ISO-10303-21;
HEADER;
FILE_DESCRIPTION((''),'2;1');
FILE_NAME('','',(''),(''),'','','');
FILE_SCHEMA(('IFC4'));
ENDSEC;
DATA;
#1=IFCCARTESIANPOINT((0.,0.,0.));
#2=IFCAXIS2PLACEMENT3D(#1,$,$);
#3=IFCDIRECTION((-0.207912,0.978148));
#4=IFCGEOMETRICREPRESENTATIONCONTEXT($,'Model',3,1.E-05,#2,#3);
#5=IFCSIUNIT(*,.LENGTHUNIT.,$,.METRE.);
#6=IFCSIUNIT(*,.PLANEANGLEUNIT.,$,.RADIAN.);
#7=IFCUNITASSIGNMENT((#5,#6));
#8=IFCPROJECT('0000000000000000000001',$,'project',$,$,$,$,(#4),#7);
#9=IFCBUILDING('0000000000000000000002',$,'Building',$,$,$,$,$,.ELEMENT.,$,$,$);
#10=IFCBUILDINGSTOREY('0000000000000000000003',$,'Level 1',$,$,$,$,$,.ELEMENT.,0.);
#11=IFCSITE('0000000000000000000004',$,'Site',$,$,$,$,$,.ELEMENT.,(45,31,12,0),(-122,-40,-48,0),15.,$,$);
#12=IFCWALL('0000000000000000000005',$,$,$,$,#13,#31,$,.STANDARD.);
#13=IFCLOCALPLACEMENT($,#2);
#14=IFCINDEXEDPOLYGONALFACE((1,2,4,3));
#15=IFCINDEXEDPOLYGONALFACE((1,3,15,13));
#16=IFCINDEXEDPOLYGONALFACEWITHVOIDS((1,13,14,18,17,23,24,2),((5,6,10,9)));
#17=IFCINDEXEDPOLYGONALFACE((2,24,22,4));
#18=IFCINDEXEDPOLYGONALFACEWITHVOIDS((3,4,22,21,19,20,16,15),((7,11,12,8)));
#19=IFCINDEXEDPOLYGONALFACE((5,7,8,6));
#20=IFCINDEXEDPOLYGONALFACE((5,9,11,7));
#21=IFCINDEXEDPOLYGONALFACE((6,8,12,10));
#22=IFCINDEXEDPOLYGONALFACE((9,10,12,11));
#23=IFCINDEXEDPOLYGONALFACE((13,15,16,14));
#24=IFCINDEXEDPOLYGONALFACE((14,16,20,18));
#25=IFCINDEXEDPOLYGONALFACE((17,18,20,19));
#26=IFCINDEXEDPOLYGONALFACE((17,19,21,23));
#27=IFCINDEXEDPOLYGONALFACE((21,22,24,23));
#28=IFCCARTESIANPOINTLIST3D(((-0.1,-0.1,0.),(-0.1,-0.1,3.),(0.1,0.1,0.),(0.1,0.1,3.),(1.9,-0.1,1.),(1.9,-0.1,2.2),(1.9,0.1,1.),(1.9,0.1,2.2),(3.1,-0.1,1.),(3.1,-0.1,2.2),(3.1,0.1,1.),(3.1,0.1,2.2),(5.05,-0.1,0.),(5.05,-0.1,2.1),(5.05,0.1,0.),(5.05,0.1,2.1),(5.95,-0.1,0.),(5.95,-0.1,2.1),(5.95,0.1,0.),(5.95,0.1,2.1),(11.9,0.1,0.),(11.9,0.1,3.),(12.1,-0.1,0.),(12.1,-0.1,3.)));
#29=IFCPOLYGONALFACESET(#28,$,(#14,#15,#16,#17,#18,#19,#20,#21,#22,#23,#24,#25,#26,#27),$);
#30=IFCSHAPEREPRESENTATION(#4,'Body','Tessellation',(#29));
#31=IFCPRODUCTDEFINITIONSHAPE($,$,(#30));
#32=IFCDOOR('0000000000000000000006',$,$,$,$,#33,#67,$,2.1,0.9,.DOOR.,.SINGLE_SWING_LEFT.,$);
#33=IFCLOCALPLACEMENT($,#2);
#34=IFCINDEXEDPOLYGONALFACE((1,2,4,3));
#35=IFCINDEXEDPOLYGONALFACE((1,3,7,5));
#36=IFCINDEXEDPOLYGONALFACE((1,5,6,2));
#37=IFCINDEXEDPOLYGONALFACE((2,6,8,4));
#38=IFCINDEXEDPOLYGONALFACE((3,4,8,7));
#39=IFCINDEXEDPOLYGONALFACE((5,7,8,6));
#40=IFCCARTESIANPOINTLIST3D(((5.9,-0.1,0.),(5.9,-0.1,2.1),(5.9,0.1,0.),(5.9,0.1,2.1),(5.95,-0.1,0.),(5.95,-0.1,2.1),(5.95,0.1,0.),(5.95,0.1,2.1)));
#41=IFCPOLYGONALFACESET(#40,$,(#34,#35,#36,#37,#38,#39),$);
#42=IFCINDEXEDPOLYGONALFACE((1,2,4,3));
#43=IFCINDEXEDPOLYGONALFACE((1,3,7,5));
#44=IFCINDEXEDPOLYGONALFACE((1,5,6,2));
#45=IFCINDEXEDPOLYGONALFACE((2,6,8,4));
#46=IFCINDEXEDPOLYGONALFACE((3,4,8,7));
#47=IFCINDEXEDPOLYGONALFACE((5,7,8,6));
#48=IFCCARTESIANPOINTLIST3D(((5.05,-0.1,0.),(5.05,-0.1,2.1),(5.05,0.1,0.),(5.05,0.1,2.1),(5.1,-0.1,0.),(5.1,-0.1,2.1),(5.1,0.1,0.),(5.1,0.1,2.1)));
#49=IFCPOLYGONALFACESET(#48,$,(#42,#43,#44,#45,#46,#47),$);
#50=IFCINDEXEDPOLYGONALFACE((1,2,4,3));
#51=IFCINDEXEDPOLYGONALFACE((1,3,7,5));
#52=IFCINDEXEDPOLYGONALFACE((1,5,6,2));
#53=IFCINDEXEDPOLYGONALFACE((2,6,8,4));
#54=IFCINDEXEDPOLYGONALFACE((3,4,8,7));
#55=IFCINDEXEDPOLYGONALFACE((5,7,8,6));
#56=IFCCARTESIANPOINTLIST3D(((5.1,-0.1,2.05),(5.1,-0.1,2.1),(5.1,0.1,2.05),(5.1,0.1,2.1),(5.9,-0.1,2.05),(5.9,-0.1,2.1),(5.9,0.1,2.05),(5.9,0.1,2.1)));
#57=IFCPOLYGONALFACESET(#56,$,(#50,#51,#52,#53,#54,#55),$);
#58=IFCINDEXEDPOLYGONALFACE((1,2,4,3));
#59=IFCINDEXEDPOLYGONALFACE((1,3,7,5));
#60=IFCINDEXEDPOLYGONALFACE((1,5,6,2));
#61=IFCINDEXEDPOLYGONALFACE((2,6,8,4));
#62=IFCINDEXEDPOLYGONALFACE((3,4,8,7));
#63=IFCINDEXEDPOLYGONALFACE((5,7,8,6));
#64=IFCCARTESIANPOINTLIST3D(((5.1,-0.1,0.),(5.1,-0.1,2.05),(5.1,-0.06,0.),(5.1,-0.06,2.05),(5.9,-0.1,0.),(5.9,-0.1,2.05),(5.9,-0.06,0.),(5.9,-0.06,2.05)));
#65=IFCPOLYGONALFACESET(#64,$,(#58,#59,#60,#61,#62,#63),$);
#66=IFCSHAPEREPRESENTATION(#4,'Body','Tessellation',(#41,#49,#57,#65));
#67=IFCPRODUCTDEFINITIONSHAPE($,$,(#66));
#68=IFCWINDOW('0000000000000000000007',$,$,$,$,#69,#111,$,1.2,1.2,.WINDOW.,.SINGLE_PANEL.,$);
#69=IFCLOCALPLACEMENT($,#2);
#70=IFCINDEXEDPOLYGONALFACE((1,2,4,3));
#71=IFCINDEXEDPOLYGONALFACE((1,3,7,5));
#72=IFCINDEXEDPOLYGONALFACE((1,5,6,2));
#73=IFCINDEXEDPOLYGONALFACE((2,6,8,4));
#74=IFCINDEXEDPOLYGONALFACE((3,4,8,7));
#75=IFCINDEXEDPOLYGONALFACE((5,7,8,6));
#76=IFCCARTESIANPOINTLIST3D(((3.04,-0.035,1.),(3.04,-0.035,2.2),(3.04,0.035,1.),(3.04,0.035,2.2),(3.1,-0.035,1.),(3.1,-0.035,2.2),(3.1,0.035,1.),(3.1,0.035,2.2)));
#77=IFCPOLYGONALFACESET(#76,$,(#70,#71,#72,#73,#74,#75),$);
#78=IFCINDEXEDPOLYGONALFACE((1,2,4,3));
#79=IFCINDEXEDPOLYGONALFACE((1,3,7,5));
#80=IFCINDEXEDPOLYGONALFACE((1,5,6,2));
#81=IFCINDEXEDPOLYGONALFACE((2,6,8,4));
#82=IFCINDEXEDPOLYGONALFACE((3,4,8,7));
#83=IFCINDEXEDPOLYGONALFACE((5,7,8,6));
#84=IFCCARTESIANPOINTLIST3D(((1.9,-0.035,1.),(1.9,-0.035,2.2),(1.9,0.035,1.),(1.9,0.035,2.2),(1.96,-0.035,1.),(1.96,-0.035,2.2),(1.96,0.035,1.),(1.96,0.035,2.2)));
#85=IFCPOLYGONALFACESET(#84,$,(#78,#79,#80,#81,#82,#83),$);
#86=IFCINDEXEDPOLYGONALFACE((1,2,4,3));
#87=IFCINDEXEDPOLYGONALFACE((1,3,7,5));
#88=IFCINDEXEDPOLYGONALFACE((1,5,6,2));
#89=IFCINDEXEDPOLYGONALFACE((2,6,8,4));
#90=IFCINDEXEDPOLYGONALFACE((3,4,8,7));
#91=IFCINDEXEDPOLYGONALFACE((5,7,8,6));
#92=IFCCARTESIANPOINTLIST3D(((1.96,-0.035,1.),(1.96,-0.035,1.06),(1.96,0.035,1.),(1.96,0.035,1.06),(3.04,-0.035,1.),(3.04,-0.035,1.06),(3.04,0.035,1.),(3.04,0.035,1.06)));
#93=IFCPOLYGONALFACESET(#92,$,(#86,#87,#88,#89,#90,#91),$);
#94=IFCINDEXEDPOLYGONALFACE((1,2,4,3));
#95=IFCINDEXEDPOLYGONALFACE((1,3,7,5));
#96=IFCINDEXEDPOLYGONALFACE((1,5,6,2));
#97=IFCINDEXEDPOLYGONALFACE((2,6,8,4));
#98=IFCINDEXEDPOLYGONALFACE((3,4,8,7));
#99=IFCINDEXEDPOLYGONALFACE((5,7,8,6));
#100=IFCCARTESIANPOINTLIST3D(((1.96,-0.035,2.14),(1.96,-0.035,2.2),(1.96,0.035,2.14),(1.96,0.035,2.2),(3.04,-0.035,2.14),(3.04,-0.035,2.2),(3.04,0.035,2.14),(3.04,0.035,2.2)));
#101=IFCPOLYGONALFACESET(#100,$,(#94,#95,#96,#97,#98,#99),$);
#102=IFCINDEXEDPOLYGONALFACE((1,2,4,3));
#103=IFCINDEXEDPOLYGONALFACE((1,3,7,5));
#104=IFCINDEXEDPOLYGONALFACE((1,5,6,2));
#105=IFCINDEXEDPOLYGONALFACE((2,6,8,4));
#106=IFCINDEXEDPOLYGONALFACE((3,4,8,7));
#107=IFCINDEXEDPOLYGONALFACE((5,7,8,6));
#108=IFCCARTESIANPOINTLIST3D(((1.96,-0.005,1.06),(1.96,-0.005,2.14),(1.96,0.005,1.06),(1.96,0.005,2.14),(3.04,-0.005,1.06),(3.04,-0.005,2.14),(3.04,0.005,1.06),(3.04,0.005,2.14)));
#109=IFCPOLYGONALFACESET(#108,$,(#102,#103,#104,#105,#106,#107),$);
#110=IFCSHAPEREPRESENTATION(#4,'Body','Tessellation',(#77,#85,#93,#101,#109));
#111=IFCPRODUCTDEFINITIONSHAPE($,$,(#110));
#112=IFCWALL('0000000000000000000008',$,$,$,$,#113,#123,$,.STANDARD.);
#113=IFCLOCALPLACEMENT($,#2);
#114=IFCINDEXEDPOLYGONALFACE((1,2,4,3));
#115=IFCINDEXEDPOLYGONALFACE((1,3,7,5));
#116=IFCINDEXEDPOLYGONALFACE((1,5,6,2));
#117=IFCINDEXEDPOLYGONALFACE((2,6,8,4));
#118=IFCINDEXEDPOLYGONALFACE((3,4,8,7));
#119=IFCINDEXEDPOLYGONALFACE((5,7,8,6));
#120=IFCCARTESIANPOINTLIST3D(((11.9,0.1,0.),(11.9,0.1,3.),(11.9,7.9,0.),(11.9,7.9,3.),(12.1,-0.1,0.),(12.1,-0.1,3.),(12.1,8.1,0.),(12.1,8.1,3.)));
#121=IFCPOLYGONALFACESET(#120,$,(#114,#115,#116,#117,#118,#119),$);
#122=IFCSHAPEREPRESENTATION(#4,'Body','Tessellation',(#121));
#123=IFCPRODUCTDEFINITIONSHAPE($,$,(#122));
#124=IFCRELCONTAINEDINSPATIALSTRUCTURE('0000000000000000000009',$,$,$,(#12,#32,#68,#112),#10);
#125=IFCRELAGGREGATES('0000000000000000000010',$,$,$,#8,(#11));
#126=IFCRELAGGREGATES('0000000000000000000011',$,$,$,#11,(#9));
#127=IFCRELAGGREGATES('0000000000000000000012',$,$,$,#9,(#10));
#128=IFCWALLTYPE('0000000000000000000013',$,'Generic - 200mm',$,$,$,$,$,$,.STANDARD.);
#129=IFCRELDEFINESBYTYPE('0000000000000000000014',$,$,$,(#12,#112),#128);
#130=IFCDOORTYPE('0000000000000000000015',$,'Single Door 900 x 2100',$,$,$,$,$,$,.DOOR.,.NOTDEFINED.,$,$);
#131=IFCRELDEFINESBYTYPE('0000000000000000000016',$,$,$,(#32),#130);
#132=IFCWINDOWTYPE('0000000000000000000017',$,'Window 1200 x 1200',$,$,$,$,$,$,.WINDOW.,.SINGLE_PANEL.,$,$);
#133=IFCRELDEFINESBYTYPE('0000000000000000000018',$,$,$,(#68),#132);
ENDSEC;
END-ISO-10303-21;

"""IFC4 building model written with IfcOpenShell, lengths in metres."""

from ifc_helpers import new_model, si_unit, direction, frame, frame_2d, origin, origin_with_axes, origin_2d, place, context, project, spatial, polyline, rectangle, outline, extrude, type_object, element, fill, save


model = new_model("IFC4")

# Units and contexts
model_context = context("Model", 3, precision=1e-05, world=origin(), true_north=direction((-0.207912, 0.978148)))
ifc_project = project(units=[si_unit("LENGTHUNIT", "METRE"), si_unit("PLANEANGLEUNIT", "RADIAN")], contexts=[model_context])

# Site, building, storey
site = spatial("IfcSite", under=ifc_project, Name="Site", CompositionType="ELEMENT", RefLatitude=(45, 31, 12, 0), RefLongitude=(-122, -40, -48, 0), RefElevation=15.0)
building = spatial("IfcBuilding", under=site, Name="Building", CompositionType="ELEMENT")
storey = spatial("IfcBuildingStorey", under=building, Name="Level 1", CompositionType="ELEMENT", Elevation=0.0)

# Wall, openings, door, window
wall_type = type_object("IfcWallType", Name="Generic - 200mm", PredefinedType="STANDARD")
wall_1_placement = place(None, frame((12.0, 0.0, 0.0), z_axis=(0.0, 0.0, 1.0), x_axis=(-1.0, 0.0, 0.0)))
wall_1 = element("IfcWall", 1, at=wall_1_placement, inside=storey, type_object=wall_type, PredefinedType="STANDARD", context=model_context, shape_type="SweptSolid", body=[
    extrude(outline(polyline([(0.1, -0.1), (11.9, -0.1), (12.1, 0.1), (-0.1, 0.1), (0.1, -0.1)])), origin(), (0.0, 0.0, 1.0), 3.0),
])
opening_1_placement = place(wall_1_placement, frame((6.5, 0.0, 0.0), z_axis=(0.0, 0.0, 1.0), x_axis=(1.0, 0.0, 0.0)))
opening_1 = element("IfcOpeningElement", 2, at=opening_1_placement, cuts=wall_1, PredefinedType="OPENING", context=model_context, shape_type="SweptSolid", body=[
    extrude(rectangle(XDim=0.9, YDim=0.202, at=origin_2d()), origin(), (0.0, 0.0, 1.0), 2.1),
])
opening_2_placement = place(wall_1_placement, frame((9.5, 0.0, 1.0), z_axis=(0.0, 0.0, 1.0), x_axis=(1.0, 0.0, 0.0)))
opening_2 = element("IfcOpeningElement", 3, at=opening_2_placement, cuts=wall_1, PredefinedType="OPENING", context=model_context, shape_type="SweptSolid", body=[
    extrude(rectangle(XDim=1.2, YDim=0.202, at=origin_2d()), origin(), (0.0, 0.0, 1.0), 1.2),
])
door_type = type_object("IfcDoorType", Name="Single Door 900 x 2100", OperationType="NOTDEFINED", PredefinedType="DOOR")
door_1_placement = place(opening_1_placement, origin_with_axes())
door_1 = element("IfcDoor", 4, at=door_1_placement, inside=storey, type_object=door_type, OperationType="SINGLE_SWING_LEFT", OverallHeight=2.1, OverallWidth=0.9, PredefinedType="DOOR", context=model_context, shape_type="SweptSolid", body=[
    extrude(rectangle(XDim=0.05, YDim=0.2, at=frame_2d((-0.425, 0.0))), origin(), (0.0, 0.0, 1.0), 2.1),
    extrude(rectangle(XDim=0.05, YDim=0.2, at=frame_2d((0.425, 0.0))), origin(), (0.0, 0.0, 1.0), 2.1),
    extrude(rectangle(XDim=0.8, YDim=0.2, at=origin_2d()), frame((0.0, 0.0, 2.05)), (0.0, 0.0, 1.0), 0.05),
    extrude(rectangle(XDim=0.8, YDim=0.04, at=frame_2d((0.0, 0.08))), origin(), (0.0, 0.0, 1.0), 2.05),
])
fill(opening_1, door_1)
window_type = type_object("IfcWindowType", Name="Window 1200 x 1200", PartitioningType="SINGLE_PANEL", PredefinedType="WINDOW")
window_1_placement = place(opening_2_placement, origin_with_axes())
window_1 = element("IfcWindow", 5, at=window_1_placement, inside=storey, type_object=window_type, OverallHeight=1.2, OverallWidth=1.2, PartitioningType="SINGLE_PANEL", PredefinedType="WINDOW", context=model_context, shape_type="SweptSolid", body=[
    extrude(rectangle(XDim=0.06, YDim=0.07, at=frame_2d((-0.57, 0.0))), origin(), (0.0, 0.0, 1.0), 1.2),
    extrude(rectangle(XDim=0.06, YDim=0.07, at=frame_2d((0.57, 0.0))), origin(), (0.0, 0.0, 1.0), 1.2),
    extrude(rectangle(XDim=1.08, YDim=0.07, at=origin_2d()), origin(), (0.0, 0.0, 1.0), 0.06),
    extrude(rectangle(XDim=1.08, YDim=0.07, at=origin_2d()), frame((0.0, 0.0, 1.14)), (0.0, 0.0, 1.0), 0.06),
    extrude(rectangle(XDim=1.08, YDim=0.01, at=origin_2d()), frame((0.0, 0.0, 0.06)), (0.0, 0.0, 1.0), 1.08),
])
fill(opening_2, window_1)

# Wall
wall_2_placement = place(None, frame((12.0, 8.0, 0.0), z_axis=(0.0, 0.0, 1.0), x_axis=(0.0, -1.0, 0.0)))
element("IfcWall", 6, at=wall_2_placement, inside=storey, type_object=wall_type, PredefinedType="STANDARD", context=model_context, shape_type="SweptSolid", body=[
    extrude(outline(polyline([(0.1, -0.1), (7.9, -0.1), (8.1, 0.1), (-0.1, 0.1), (0.1, -0.1)])), origin(), (0.0, 0.0, 1.0), 3.0),
])

save(model, "model.ifc")
